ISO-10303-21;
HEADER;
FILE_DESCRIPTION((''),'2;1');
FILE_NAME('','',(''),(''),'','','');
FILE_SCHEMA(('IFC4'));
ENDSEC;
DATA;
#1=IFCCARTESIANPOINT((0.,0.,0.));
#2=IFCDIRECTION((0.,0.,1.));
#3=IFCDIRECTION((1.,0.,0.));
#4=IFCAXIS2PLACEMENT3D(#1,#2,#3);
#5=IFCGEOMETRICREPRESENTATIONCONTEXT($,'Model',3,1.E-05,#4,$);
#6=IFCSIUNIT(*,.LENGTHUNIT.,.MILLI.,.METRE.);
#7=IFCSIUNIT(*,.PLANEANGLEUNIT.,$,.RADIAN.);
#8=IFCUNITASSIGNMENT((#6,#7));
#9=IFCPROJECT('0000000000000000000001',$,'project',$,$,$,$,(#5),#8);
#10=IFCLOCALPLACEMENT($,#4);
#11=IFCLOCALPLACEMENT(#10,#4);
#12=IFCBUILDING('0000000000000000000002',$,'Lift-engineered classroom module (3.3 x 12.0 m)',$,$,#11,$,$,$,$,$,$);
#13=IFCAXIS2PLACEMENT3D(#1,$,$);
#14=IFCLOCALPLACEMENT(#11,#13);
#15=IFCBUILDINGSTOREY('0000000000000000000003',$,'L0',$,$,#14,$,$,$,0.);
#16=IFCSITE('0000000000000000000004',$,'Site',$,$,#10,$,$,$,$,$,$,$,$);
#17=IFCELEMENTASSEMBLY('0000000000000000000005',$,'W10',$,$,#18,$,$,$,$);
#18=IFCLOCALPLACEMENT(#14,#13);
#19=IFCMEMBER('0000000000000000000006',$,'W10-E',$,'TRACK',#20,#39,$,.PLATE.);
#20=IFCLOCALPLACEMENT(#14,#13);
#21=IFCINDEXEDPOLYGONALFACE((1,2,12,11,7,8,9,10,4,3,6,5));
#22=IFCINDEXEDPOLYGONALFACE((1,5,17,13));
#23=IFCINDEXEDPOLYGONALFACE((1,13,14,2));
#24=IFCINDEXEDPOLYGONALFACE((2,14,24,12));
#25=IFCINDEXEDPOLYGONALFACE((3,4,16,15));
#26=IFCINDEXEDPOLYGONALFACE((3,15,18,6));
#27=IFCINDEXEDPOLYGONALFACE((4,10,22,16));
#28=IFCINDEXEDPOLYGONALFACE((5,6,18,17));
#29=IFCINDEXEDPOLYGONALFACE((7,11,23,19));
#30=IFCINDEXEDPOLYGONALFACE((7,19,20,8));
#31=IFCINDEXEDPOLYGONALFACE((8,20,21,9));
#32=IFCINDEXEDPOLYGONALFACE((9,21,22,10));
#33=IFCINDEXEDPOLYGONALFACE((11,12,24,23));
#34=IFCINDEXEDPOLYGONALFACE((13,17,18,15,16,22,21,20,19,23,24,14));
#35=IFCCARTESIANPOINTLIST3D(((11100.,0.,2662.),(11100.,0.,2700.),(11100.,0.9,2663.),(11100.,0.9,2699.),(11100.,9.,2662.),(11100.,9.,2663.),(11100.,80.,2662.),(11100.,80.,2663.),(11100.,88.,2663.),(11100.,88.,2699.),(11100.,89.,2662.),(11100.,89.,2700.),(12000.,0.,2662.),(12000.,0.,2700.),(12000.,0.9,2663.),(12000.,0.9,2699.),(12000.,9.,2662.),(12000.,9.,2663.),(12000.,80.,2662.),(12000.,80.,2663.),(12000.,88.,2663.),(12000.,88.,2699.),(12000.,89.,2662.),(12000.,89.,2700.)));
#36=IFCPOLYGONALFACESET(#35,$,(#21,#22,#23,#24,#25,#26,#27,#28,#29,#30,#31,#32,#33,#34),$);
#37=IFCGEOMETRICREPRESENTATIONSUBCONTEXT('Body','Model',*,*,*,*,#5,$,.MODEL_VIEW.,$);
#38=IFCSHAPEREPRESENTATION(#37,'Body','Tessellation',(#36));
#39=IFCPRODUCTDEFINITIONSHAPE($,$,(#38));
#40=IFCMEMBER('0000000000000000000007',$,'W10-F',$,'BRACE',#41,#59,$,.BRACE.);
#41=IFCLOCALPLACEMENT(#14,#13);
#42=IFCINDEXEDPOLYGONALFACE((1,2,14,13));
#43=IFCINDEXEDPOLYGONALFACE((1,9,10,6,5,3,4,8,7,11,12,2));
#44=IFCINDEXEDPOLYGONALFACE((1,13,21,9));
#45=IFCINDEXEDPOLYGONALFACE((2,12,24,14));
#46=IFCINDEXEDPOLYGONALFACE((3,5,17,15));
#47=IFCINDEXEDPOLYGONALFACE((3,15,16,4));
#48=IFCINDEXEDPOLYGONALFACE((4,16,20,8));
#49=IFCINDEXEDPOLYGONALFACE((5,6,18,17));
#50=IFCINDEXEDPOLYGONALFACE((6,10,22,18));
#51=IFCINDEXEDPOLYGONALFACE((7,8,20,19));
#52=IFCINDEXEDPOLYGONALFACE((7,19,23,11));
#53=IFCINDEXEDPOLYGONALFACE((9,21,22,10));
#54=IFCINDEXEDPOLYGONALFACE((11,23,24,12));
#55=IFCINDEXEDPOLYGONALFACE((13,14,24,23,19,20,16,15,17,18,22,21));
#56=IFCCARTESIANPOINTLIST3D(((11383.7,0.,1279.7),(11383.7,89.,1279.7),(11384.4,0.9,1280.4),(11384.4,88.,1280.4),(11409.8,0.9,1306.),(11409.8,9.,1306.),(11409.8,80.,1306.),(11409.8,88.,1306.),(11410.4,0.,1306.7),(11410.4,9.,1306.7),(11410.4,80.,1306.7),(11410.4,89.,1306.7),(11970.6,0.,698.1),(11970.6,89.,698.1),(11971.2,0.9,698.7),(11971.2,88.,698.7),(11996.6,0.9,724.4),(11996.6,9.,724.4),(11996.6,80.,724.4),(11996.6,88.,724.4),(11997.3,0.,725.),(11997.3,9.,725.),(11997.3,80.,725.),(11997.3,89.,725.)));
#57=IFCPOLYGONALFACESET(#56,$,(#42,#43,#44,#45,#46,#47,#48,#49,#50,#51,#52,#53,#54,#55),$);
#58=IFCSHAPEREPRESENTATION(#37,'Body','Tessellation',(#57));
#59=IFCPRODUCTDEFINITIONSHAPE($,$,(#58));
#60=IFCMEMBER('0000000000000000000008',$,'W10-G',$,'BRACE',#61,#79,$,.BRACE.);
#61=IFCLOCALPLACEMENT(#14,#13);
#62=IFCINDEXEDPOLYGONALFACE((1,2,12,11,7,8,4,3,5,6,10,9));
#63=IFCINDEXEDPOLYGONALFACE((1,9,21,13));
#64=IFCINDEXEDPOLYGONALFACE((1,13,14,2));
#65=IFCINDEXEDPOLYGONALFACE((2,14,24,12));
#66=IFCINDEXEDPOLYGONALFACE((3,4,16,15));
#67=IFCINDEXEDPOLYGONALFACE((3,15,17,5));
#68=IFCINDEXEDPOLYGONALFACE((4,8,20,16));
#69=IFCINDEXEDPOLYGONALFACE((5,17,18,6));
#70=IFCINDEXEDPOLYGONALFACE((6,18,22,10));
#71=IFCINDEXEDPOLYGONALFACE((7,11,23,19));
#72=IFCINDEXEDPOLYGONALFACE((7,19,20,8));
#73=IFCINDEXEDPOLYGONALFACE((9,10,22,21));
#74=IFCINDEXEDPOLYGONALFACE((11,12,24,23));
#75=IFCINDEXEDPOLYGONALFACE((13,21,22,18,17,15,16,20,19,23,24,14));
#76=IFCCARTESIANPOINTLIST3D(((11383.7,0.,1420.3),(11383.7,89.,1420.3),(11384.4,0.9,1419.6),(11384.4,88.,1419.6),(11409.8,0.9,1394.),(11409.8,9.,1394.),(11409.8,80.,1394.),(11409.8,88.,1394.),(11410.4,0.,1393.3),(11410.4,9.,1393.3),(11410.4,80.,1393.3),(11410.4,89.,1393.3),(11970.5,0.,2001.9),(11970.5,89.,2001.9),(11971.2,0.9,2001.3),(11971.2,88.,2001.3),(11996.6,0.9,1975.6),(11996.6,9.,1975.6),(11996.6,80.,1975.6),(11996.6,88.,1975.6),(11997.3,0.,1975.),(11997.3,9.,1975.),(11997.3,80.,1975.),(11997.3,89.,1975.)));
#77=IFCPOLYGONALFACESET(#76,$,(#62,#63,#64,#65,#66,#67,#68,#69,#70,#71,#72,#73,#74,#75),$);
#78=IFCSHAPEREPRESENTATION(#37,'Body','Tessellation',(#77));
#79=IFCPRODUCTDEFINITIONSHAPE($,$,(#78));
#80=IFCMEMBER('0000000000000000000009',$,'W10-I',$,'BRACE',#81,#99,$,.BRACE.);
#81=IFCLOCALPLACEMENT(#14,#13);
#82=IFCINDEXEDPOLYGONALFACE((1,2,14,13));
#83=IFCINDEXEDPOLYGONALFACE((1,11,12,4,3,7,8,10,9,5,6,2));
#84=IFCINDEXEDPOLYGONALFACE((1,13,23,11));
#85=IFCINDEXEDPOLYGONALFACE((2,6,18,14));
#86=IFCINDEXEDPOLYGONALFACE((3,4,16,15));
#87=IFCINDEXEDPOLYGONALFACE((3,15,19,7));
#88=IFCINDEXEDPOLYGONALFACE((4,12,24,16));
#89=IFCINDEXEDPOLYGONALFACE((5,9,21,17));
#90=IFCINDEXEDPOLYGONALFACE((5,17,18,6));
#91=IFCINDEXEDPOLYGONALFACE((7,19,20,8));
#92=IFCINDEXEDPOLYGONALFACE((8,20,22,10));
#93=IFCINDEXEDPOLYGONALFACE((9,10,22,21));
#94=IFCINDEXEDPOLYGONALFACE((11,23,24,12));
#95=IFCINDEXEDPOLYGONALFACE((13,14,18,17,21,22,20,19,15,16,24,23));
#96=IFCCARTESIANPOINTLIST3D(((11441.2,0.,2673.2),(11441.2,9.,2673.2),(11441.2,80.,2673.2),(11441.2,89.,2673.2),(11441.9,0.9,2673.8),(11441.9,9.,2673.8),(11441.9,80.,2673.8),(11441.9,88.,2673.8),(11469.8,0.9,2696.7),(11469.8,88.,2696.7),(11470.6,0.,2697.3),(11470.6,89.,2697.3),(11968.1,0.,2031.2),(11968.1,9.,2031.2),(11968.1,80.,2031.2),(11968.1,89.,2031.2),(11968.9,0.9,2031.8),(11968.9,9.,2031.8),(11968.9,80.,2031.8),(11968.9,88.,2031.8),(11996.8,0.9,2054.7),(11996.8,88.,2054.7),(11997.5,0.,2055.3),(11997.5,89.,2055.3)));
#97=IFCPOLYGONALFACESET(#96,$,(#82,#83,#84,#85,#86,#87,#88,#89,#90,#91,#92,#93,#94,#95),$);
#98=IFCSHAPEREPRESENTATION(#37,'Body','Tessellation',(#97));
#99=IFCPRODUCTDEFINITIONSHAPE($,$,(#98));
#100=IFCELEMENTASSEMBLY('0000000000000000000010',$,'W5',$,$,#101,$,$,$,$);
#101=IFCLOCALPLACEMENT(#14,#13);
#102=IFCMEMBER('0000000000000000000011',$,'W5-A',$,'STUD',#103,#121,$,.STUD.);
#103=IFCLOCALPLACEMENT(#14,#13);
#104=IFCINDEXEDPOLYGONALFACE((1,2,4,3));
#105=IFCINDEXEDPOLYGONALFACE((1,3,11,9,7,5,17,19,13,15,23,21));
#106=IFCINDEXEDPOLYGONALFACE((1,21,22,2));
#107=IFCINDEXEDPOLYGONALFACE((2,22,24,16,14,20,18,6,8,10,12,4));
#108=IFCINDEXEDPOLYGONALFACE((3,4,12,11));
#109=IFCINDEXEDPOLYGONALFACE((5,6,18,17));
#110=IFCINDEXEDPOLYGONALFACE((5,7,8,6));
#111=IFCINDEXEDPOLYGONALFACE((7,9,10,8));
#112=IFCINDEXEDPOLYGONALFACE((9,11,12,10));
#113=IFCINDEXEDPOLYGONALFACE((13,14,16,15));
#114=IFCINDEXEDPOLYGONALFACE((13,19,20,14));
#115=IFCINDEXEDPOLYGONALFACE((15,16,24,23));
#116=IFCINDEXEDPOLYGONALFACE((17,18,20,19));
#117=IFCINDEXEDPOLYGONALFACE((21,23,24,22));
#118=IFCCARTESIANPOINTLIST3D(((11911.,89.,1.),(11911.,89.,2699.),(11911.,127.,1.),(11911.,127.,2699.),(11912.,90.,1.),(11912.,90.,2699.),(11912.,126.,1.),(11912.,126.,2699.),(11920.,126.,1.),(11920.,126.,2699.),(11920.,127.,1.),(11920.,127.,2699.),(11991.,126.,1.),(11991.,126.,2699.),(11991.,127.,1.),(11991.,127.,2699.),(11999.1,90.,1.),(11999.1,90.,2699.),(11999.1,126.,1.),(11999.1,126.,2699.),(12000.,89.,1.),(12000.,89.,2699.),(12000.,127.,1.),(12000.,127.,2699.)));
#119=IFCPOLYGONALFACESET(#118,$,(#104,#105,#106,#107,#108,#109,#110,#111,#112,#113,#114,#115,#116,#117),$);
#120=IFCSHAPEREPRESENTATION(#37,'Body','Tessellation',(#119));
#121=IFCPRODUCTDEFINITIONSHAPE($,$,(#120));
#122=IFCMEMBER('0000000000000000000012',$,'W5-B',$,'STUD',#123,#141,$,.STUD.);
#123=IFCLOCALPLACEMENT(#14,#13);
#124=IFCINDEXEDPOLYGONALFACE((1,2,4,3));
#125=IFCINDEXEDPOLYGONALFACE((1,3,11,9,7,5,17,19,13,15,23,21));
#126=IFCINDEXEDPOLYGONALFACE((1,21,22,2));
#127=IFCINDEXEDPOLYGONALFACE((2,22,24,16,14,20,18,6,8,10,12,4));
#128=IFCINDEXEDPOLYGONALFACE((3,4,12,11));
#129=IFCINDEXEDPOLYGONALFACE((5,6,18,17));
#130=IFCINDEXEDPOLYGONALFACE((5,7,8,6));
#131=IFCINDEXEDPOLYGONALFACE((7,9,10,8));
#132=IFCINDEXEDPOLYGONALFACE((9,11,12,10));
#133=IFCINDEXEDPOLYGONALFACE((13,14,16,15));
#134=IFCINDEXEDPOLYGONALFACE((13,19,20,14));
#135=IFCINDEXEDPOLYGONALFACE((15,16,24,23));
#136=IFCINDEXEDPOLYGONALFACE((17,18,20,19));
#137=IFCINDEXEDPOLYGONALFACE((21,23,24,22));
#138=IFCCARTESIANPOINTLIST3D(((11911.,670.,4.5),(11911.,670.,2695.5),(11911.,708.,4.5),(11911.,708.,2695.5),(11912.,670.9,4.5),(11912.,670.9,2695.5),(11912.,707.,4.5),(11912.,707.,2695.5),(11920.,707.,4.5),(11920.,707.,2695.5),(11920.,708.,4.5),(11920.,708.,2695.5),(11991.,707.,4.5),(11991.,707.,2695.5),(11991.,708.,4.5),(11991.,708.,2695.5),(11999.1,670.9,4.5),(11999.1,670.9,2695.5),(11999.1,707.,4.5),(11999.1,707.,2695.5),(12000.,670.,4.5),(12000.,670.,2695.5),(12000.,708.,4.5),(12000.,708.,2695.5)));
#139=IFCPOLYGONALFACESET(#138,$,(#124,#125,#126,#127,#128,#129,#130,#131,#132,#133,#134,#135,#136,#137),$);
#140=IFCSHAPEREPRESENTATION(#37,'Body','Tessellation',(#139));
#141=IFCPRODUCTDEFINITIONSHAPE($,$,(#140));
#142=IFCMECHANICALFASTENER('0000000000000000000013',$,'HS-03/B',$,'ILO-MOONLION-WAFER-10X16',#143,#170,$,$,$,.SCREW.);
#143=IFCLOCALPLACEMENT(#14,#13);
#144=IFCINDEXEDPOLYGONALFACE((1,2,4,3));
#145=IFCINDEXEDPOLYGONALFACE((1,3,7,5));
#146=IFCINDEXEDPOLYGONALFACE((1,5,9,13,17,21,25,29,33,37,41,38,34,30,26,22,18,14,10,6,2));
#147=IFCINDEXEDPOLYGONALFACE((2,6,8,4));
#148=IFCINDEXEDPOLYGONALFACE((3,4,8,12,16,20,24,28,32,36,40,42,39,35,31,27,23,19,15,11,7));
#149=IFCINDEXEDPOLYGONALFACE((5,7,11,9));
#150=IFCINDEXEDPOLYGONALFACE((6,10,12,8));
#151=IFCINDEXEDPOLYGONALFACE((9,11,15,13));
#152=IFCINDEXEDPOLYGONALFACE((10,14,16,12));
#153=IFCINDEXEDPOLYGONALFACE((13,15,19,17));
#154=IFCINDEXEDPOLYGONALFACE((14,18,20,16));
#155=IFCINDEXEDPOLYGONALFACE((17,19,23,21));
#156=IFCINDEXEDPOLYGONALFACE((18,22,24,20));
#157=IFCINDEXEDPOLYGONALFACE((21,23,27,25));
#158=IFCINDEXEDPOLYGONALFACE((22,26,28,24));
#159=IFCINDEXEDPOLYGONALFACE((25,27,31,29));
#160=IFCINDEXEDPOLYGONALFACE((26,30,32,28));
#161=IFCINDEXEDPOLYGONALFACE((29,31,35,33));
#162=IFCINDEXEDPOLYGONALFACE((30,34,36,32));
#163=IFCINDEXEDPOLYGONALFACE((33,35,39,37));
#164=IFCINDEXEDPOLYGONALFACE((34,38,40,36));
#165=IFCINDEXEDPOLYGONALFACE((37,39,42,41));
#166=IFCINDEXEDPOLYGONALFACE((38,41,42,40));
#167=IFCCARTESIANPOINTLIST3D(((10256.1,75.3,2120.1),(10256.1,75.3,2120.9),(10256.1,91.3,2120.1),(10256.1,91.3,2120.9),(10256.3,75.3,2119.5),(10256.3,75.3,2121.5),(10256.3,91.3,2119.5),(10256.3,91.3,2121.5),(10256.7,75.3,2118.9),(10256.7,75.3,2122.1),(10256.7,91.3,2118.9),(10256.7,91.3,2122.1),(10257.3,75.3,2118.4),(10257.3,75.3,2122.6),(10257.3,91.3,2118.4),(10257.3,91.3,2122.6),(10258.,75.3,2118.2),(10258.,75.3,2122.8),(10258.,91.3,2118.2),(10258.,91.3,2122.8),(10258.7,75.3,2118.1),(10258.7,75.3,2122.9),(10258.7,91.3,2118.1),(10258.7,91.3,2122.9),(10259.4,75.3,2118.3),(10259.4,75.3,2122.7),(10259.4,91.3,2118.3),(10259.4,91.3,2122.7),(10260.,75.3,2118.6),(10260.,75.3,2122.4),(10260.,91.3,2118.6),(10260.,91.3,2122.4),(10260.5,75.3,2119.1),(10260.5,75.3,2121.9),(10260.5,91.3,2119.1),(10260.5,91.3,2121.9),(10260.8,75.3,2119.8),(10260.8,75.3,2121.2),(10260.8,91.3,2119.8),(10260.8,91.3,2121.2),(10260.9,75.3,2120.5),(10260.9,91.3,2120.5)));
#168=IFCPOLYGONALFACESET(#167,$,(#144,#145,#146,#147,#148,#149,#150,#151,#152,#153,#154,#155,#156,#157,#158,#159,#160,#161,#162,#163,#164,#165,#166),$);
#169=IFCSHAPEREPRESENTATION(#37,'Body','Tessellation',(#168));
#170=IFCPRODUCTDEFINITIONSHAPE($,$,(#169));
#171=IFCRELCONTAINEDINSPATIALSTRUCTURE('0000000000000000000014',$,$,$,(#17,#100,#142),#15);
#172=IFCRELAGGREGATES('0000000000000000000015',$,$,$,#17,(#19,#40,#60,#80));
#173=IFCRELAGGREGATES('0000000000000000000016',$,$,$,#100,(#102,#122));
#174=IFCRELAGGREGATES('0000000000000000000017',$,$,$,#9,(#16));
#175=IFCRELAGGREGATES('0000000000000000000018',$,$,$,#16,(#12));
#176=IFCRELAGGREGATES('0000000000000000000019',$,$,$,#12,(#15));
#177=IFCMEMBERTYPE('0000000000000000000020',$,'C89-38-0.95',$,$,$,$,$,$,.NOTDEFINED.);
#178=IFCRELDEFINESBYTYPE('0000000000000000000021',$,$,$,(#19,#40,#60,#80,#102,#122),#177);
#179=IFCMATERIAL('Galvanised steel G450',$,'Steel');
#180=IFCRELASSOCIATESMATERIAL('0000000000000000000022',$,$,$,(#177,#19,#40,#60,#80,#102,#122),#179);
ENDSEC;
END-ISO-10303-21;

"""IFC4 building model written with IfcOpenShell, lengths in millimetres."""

from ifc_helpers import new_model, si_unit, frame, origin, origin_with_axes, origin_2d, place, context, subcontext, project, spatial, circle, c_section, extrude, material, material_profile, profile_set, profile_usage, type_object, element, aggregate, save


model = new_model("IFC4")

# Units and contexts
model_context = context("Model", 3, precision=1e-05, world=origin_with_axes())
body_context = subcontext(model_context, "Body", "Model", "MODEL_VIEW")
ifc_project = project(units=[si_unit("LENGTHUNIT", "METRE", prefix="MILLI"), si_unit("PLANEANGLEUNIT", "RADIAN")], contexts=[model_context])

# Site, building, storey
site_placement = place(None, origin_with_axes())
site = spatial("IfcSite", under=ifc_project, at=site_placement, Name="Site")
building_placement = place(site_placement, origin_with_axes())
building = spatial("IfcBuilding", under=site, at=building_placement, Name="Lift-engineered classroom module (3.3 x 12.0 m)")
storey_placement = place(building_placement, origin())
storey = spatial("IfcBuildingStorey", under=building, at=storey_placement, Name="L0", Elevation=0.0)

# Element assemblies, members
ifc_material = material(Name="Galvanised steel G450", Category="Steel")
ifc_material_profile = material_profile(ifc_material, c_section(Depth=89.0, Width=38.0, WallThickness=0.9, Girth=9.0, at=origin_2d()), Name="C89-38-0.95")
ifc_profile_set = profile_set([ifc_material_profile], Name="C89-38-0.95")
ifc_profile_usage = profile_usage(ifc_profile_set)
member_type = type_object("IfcMemberType", Name="C89-38-0.95", PredefinedType="NOTDEFINED", material=ifc_profile_set)
assembly_1_placement = place(storey_placement, frame((11100.0, 44.5, 0.0)))
assembly_1 = element("IfcElementAssembly", 1, at=assembly_1_placement, inside=storey, Name="W10")
member_1_placement = place(assembly_1_placement, frame((900.0, 0.0, 2681.0), z_axis=(-1.0, 0.0, 0.0), x_axis=(0.0, 0.0, -1.0)))
member_1 = element("IfcMember", 2, at=member_1_placement, type_object=member_type, material=ifc_profile_usage, Name="W10-E", ObjectType="TRACK", PredefinedType="PLATE", context=body_context, shape_type="SweptSolid", body=[
    extrude(c_section(Depth=89.0, Width=38.0, WallThickness=0.9, Girth=9.0, at=origin_2d()), origin(), (0.0, 0.0, 1.0), 900.0),
])
member_2_placement = place(assembly_1_placement, frame((297.1, 0.0, 1293.2), z_axis=(0.710234, 0.0, -0.703965), x_axis=(0.703965, 0.0, 0.710234)))
member_2 = element("IfcMember", 3, at=member_2_placement, type_object=member_type, material=ifc_profile_usage, Name="W10-F", ObjectType="BRACE", PredefinedType="BRACE", context=body_context, shape_type="SweptSolid", body=[
    extrude(c_section(Depth=89.0, Width=38.0, WallThickness=0.9, Girth=9.0, at=origin_2d()), origin(), (0.0, 0.0, 1.0), 826.3),
])
member_3_placement = place(assembly_1_placement, frame((883.9, 0.0, 1988.4), z_axis=(-0.710234, 0.0, -0.703965), x_axis=(0.703965, 0.0, -0.710234)))
member_3 = element("IfcMember", 4, at=member_3_placement, type_object=member_type, material=ifc_profile_usage, Name="W10-G", ObjectType="BRACE", PredefinedType="BRACE", context=body_context, shape_type="SweptSolid", body=[
    extrude(c_section(Depth=89.0, Width=38.0, WallThickness=0.9, Girth=9.0, at=origin_2d()), origin(), (0.0, 0.0, 1.0), 826.3),
])
member_4_placement = place(assembly_1_placement, frame((882.8, 0.0, 2043.3), z_axis=(-0.634443, 0.0, 0.77297), x_axis=(-0.77297, 0.0, -0.634443)))
member_4 = element("IfcMember", 5, at=member_4_placement, type_object=member_type, material=ifc_profile_usage, Name="W10-I", ObjectType="BRACE", PredefinedType="BRACE", context=body_context, shape_type="SweptSolid", body=[
    extrude(c_section(Depth=89.0, Width=38.0, WallThickness=0.9, Girth=9.0, at=origin_2d()), origin(), (0.0, 0.0, 1.0), 830.5),
])
aggregate(assembly_1, [member_1, member_2, member_3, member_4])
assembly_2_placement = place(storey_placement, frame((11955.5, 89.0, 0.0)))
assembly_2 = element("IfcElementAssembly", 6, at=assembly_2_placement, inside=storey, Name="W5")
member_5_placement = place(assembly_2_placement, frame((0.0, 19.0, 2699.1), z_axis=(0.0, 0.0, -1.0), x_axis=(0.0, 1.0, 0.0)))
member_5 = element("IfcMember", 7, at=member_5_placement, type_object=member_type, material=ifc_profile_usage, Name="W5-A", ObjectType="STUD", PredefinedType="STUD", context=body_context, shape_type="SweptSolid", body=[
    extrude(c_section(Depth=89.0, Width=38.0, WallThickness=0.9, Girth=9.0, at=origin_2d()), origin(), (0.0, 0.0, 1.0), 2698.1),
])
member_6_placement = place(assembly_2_placement, frame((0.0, 600.0, 2695.5), z_axis=(0.0, 0.0, -1.0), x_axis=(0.0, 1.0, 0.0)))
member_6 = element("IfcMember", 8, at=member_6_placement, type_object=member_type, material=ifc_profile_usage, Name="W5-B", ObjectType="STUD", PredefinedType="STUD", context=body_context, shape_type="SweptSolid", body=[
    extrude(c_section(Depth=89.0, Width=38.0, WallThickness=0.9, Girth=9.0, at=origin_2d()), origin(), (0.0, 0.0, 1.0), 2691.0),
])
aggregate(assembly_2, [member_5, member_6])

# Mechanical fastener
mechanical_fastener_placement = place(None, frame((10258.5, 89.8, 2120.5), z_axis=(0.0, -1.0, 0.0), x_axis=(1.0, 0.0, 0.0)))
element("IfcMechanicalFastener", 9, at=mechanical_fastener_placement, inside=storey, Name="HS-03/B", ObjectType="ILO-MOONLION-WAFER-10X16", PredefinedType="SCREW", context=body_context, shape_type="SweptSolid", body=[
    extrude(circle(Radius=2.4, at=origin_2d()), frame((0.0, 0.0, -1.5), z_axis=(0.0, 0.0, 1.0), x_axis=(1.0, 0.0, 0.0)), (0.0, 0.0, 1.0), 16.0),
])

save(model, "model.ifc")
